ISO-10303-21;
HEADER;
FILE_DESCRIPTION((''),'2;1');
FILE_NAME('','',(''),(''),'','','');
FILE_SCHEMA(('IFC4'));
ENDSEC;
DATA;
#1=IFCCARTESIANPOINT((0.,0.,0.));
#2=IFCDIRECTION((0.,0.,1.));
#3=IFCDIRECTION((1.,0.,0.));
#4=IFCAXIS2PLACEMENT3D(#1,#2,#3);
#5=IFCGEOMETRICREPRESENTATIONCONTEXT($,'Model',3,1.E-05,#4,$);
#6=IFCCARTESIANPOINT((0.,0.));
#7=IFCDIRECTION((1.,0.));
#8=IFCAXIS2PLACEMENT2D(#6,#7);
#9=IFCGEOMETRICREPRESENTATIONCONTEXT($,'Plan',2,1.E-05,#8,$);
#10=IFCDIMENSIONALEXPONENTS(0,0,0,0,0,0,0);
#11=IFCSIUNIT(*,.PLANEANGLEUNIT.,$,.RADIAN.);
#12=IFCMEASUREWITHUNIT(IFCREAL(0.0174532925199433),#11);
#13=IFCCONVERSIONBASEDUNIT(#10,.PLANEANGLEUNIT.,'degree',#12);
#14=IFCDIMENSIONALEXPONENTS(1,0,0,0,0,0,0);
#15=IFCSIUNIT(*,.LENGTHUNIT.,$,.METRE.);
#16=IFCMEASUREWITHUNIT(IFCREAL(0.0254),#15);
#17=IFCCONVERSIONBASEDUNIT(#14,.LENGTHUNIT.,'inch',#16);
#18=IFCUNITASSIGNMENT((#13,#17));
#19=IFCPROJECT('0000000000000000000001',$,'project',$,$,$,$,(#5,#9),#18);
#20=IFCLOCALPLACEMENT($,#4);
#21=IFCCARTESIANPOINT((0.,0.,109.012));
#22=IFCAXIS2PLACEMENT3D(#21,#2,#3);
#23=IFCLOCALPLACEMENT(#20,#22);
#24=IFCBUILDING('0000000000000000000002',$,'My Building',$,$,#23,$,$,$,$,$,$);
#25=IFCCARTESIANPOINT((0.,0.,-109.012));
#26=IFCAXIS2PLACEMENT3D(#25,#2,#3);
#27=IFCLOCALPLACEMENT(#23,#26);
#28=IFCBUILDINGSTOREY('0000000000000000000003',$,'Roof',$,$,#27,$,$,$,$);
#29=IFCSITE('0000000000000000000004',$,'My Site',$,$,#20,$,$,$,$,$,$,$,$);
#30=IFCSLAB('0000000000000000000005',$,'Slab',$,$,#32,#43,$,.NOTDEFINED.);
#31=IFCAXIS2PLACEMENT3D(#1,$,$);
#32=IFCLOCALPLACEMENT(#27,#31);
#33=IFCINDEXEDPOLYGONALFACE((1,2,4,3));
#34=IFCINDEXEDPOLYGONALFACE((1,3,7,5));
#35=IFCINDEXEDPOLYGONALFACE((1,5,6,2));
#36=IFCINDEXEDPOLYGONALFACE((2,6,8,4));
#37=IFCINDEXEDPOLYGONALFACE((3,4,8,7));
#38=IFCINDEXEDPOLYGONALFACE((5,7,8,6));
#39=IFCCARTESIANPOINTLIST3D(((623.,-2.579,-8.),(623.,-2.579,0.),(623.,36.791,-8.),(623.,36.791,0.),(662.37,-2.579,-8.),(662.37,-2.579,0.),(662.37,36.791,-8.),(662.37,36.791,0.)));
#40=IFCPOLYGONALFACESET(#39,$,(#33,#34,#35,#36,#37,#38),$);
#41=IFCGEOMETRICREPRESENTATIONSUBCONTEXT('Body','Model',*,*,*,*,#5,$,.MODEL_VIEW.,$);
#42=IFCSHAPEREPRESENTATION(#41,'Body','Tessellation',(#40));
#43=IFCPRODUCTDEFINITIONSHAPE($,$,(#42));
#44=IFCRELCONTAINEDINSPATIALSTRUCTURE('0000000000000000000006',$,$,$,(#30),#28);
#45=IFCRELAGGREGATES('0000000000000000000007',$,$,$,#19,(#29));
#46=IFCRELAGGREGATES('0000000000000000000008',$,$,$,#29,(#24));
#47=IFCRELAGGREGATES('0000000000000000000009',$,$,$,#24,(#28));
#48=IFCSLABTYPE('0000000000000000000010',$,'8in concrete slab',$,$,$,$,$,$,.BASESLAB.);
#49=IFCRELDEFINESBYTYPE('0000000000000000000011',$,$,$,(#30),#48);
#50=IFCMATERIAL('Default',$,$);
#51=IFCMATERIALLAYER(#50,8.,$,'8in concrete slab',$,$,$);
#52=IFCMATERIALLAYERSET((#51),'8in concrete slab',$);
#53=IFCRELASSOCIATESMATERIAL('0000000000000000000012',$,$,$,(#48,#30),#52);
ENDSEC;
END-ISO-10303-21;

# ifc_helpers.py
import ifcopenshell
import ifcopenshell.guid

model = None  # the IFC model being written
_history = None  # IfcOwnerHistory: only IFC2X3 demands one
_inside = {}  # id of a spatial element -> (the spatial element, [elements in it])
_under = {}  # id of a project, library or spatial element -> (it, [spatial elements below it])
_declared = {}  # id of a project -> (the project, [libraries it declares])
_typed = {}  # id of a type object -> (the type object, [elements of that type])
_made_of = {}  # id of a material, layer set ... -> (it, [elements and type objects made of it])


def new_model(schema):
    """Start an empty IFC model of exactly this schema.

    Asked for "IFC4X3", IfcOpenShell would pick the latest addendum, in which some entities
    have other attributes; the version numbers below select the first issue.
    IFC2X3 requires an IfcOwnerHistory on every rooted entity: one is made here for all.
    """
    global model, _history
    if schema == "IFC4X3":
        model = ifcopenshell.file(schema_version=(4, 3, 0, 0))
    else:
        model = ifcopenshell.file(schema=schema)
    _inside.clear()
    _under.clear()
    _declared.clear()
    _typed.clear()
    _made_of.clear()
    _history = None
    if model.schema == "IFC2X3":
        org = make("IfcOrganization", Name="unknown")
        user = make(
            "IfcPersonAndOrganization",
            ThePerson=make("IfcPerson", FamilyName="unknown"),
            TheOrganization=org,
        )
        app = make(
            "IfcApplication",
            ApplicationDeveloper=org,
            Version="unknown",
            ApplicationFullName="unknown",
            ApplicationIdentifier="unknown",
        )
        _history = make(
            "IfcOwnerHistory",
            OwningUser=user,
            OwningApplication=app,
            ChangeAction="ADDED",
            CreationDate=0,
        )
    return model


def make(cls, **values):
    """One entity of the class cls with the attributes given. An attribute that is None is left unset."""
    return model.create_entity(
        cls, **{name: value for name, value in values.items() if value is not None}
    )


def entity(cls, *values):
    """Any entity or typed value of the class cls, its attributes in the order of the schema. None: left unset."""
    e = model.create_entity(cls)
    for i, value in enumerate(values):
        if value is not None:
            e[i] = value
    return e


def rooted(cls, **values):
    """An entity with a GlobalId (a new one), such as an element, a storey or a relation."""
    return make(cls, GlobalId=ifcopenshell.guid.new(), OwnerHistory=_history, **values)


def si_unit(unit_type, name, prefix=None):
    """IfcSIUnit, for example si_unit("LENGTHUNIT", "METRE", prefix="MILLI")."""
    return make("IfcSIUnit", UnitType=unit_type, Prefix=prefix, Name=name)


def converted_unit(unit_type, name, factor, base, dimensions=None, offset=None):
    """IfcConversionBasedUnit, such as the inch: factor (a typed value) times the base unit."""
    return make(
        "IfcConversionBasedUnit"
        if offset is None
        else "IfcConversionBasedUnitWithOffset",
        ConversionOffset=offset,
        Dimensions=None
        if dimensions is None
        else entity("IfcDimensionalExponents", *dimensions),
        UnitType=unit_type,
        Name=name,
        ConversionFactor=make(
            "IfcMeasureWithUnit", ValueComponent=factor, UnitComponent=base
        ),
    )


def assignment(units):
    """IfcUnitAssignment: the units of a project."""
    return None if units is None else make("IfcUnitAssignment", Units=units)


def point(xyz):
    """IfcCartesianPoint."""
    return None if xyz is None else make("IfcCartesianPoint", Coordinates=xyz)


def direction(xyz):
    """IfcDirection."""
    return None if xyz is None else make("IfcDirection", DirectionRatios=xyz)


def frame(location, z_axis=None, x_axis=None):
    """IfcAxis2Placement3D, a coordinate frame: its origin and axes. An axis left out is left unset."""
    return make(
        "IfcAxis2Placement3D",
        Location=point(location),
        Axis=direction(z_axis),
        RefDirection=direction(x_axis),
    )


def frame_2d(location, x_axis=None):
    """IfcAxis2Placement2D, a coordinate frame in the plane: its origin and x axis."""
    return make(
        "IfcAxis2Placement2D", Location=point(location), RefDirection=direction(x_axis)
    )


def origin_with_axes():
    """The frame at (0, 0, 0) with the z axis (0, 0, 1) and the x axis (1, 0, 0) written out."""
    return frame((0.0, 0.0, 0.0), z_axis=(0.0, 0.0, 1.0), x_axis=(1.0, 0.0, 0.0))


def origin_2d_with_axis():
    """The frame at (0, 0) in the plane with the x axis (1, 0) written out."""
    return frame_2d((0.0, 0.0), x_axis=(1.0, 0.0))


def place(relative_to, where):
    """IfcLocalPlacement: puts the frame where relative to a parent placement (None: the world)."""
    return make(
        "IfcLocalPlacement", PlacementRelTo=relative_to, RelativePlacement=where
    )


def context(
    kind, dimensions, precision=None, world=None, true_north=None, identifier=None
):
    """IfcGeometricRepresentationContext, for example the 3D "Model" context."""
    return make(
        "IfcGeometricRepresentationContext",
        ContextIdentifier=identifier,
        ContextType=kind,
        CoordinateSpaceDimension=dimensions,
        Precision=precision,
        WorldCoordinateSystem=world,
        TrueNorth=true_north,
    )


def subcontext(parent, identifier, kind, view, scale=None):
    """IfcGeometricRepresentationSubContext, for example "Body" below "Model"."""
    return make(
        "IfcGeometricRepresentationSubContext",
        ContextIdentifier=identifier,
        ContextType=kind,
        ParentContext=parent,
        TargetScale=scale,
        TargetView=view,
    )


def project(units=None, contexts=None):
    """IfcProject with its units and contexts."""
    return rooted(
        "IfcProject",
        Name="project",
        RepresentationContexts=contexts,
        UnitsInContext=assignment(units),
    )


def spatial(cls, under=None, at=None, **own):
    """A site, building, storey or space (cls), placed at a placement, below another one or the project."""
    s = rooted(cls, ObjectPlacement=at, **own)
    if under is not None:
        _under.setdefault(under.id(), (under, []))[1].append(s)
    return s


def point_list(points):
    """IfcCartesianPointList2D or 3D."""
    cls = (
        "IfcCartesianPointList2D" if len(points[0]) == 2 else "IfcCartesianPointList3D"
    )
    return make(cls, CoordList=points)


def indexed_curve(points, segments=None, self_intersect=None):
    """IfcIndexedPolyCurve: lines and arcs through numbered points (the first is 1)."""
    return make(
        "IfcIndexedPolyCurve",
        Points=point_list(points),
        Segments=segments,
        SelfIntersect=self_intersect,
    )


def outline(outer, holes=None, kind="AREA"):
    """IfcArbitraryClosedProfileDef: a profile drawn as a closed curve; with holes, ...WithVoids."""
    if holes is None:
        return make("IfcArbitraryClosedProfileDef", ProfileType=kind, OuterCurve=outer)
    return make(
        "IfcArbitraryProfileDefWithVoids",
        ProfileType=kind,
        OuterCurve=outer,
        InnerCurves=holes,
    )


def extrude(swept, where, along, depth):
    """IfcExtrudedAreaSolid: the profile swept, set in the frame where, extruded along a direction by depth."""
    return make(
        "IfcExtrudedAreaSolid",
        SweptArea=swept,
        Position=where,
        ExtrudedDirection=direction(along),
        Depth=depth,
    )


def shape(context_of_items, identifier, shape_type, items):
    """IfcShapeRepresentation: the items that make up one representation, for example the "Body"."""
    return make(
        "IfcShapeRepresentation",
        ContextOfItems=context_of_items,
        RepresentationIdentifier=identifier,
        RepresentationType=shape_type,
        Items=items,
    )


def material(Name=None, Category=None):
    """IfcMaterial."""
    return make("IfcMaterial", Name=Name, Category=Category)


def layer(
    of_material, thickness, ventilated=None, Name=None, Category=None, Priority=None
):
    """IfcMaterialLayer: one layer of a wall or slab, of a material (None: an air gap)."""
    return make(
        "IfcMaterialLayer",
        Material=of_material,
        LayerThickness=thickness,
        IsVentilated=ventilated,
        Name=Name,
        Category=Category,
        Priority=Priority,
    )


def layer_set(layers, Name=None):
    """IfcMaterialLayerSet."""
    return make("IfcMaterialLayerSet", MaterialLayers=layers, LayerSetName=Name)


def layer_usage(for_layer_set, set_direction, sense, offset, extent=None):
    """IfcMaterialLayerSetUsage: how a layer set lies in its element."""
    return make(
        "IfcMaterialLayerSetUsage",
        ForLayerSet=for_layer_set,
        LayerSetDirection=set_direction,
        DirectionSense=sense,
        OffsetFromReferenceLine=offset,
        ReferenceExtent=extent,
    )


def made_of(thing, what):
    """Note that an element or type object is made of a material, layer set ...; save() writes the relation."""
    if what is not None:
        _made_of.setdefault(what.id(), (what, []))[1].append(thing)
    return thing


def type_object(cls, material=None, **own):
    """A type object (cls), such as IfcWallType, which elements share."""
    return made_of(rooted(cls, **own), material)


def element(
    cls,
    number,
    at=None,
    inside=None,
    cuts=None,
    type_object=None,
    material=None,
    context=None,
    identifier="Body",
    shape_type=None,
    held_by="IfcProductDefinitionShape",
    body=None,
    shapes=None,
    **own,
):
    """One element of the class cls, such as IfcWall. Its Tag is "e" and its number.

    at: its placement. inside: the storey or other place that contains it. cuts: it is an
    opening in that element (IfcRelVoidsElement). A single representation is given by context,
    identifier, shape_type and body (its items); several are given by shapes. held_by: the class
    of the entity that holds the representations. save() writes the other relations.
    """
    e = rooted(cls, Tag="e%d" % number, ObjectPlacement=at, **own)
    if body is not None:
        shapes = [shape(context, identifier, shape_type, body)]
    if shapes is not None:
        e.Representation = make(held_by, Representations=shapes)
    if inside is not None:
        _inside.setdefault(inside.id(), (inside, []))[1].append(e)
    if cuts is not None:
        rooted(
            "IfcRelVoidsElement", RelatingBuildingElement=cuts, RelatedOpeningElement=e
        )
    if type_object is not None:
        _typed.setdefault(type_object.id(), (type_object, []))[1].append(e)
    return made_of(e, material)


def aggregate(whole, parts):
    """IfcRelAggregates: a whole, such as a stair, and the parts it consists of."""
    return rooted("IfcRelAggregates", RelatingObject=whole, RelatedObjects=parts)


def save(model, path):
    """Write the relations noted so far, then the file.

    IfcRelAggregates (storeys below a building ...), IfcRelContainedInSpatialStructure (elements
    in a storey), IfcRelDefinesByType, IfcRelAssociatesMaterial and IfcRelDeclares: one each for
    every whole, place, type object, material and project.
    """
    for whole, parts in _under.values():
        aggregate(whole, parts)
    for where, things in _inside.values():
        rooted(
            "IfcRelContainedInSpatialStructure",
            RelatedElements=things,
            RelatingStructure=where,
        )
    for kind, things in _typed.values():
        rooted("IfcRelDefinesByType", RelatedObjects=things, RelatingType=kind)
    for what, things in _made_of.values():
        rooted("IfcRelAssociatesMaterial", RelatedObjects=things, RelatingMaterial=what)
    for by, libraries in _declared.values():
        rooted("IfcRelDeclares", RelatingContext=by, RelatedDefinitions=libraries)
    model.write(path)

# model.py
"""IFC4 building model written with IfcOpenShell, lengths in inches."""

from ifc_helpers import new_model, entity, si_unit, converted_unit, frame, origin_with_axes, origin_2d_with_axis, place, context, subcontext, project, spatial, indexed_curve, outline, extrude, material, layer, layer_set, layer_usage, type_object, element, save


model = new_model("IFC4")

# Units and contexts
model_context = context("Model", 3, precision=1e-05, world=origin_with_axes())
plan_context = context("Plan", 2, precision=1e-05, world=origin_2d_with_axis())
body_context = subcontext(model_context, "Body", "Model", "MODEL_VIEW")
ifc_project = project(units=[converted_unit("PLANEANGLEUNIT", "degree", entity("IfcReal", 0.0174532925199433), si_unit("PLANEANGLEUNIT", "RADIAN"), dimensions=[0, 0, 0, 0, 0, 0, 0]), converted_unit("LENGTHUNIT", "inch", entity("IfcReal", 0.0254), si_unit("LENGTHUNIT", "METRE"), dimensions=[1, 0, 0, 0, 0, 0, 0])], contexts=[model_context, plan_context])

# Site, building, storey
site_placement = place(None, origin_with_axes())
site = spatial("IfcSite", under=ifc_project, at=site_placement, Name="My Site")
building_placement = place(site_placement, frame((0.0, 0.0, 109.012), z_axis=(0.0, 0.0, 1.0), x_axis=(1.0, 0.0, 0.0)))
building = spatial("IfcBuilding", under=site, at=building_placement, Name="My Building")
storey_placement = place(building_placement, frame((0.0, 0.0, -109.012), z_axis=(0.0, 0.0, 1.0), x_axis=(1.0, 0.0, 0.0)))
storey = spatial("IfcBuildingStorey", under=building, at=storey_placement, Name="Roof")

# Shared definitions
ifc_material = material(Name="Default")

# Slab
ifc_layer_1 = layer(ifc_material, 8.0, Name="8in concrete slab")
ifc_layer_set_1 = layer_set([ifc_layer_1], Name="8in concrete slab")
ifc_layer_usage_1 = layer_usage(ifc_layer_set_1, "AXIS3", "POSITIVE", 0.0)
slab_type = type_object("IfcSlabType", Name="8in concrete slab", PredefinedType="BASESLAB", material=ifc_layer_set_1)
slab_placement = place(storey_placement, frame((623.0, -2.579, -8.0), z_axis=(0.0, 0.0, 1.0), x_axis=(1.0, 0.0, 0.0)))
element("IfcSlab", 1, at=slab_placement, inside=storey, type_object=slab_type, material=ifc_layer_usage_1, Name="Slab", PredefinedType="NOTDEFINED", context=body_context, shape_type="SweptSolid", body=[
    extrude(outline(indexed_curve([(0.0, 0.0), (39.37, 0.0), (39.37, 39.37), (0.0, 39.37), (0.0, 0.0)])), None, (0.0, 0.0, 1.0), 8.0),
])

save(model, "model.ifc")
